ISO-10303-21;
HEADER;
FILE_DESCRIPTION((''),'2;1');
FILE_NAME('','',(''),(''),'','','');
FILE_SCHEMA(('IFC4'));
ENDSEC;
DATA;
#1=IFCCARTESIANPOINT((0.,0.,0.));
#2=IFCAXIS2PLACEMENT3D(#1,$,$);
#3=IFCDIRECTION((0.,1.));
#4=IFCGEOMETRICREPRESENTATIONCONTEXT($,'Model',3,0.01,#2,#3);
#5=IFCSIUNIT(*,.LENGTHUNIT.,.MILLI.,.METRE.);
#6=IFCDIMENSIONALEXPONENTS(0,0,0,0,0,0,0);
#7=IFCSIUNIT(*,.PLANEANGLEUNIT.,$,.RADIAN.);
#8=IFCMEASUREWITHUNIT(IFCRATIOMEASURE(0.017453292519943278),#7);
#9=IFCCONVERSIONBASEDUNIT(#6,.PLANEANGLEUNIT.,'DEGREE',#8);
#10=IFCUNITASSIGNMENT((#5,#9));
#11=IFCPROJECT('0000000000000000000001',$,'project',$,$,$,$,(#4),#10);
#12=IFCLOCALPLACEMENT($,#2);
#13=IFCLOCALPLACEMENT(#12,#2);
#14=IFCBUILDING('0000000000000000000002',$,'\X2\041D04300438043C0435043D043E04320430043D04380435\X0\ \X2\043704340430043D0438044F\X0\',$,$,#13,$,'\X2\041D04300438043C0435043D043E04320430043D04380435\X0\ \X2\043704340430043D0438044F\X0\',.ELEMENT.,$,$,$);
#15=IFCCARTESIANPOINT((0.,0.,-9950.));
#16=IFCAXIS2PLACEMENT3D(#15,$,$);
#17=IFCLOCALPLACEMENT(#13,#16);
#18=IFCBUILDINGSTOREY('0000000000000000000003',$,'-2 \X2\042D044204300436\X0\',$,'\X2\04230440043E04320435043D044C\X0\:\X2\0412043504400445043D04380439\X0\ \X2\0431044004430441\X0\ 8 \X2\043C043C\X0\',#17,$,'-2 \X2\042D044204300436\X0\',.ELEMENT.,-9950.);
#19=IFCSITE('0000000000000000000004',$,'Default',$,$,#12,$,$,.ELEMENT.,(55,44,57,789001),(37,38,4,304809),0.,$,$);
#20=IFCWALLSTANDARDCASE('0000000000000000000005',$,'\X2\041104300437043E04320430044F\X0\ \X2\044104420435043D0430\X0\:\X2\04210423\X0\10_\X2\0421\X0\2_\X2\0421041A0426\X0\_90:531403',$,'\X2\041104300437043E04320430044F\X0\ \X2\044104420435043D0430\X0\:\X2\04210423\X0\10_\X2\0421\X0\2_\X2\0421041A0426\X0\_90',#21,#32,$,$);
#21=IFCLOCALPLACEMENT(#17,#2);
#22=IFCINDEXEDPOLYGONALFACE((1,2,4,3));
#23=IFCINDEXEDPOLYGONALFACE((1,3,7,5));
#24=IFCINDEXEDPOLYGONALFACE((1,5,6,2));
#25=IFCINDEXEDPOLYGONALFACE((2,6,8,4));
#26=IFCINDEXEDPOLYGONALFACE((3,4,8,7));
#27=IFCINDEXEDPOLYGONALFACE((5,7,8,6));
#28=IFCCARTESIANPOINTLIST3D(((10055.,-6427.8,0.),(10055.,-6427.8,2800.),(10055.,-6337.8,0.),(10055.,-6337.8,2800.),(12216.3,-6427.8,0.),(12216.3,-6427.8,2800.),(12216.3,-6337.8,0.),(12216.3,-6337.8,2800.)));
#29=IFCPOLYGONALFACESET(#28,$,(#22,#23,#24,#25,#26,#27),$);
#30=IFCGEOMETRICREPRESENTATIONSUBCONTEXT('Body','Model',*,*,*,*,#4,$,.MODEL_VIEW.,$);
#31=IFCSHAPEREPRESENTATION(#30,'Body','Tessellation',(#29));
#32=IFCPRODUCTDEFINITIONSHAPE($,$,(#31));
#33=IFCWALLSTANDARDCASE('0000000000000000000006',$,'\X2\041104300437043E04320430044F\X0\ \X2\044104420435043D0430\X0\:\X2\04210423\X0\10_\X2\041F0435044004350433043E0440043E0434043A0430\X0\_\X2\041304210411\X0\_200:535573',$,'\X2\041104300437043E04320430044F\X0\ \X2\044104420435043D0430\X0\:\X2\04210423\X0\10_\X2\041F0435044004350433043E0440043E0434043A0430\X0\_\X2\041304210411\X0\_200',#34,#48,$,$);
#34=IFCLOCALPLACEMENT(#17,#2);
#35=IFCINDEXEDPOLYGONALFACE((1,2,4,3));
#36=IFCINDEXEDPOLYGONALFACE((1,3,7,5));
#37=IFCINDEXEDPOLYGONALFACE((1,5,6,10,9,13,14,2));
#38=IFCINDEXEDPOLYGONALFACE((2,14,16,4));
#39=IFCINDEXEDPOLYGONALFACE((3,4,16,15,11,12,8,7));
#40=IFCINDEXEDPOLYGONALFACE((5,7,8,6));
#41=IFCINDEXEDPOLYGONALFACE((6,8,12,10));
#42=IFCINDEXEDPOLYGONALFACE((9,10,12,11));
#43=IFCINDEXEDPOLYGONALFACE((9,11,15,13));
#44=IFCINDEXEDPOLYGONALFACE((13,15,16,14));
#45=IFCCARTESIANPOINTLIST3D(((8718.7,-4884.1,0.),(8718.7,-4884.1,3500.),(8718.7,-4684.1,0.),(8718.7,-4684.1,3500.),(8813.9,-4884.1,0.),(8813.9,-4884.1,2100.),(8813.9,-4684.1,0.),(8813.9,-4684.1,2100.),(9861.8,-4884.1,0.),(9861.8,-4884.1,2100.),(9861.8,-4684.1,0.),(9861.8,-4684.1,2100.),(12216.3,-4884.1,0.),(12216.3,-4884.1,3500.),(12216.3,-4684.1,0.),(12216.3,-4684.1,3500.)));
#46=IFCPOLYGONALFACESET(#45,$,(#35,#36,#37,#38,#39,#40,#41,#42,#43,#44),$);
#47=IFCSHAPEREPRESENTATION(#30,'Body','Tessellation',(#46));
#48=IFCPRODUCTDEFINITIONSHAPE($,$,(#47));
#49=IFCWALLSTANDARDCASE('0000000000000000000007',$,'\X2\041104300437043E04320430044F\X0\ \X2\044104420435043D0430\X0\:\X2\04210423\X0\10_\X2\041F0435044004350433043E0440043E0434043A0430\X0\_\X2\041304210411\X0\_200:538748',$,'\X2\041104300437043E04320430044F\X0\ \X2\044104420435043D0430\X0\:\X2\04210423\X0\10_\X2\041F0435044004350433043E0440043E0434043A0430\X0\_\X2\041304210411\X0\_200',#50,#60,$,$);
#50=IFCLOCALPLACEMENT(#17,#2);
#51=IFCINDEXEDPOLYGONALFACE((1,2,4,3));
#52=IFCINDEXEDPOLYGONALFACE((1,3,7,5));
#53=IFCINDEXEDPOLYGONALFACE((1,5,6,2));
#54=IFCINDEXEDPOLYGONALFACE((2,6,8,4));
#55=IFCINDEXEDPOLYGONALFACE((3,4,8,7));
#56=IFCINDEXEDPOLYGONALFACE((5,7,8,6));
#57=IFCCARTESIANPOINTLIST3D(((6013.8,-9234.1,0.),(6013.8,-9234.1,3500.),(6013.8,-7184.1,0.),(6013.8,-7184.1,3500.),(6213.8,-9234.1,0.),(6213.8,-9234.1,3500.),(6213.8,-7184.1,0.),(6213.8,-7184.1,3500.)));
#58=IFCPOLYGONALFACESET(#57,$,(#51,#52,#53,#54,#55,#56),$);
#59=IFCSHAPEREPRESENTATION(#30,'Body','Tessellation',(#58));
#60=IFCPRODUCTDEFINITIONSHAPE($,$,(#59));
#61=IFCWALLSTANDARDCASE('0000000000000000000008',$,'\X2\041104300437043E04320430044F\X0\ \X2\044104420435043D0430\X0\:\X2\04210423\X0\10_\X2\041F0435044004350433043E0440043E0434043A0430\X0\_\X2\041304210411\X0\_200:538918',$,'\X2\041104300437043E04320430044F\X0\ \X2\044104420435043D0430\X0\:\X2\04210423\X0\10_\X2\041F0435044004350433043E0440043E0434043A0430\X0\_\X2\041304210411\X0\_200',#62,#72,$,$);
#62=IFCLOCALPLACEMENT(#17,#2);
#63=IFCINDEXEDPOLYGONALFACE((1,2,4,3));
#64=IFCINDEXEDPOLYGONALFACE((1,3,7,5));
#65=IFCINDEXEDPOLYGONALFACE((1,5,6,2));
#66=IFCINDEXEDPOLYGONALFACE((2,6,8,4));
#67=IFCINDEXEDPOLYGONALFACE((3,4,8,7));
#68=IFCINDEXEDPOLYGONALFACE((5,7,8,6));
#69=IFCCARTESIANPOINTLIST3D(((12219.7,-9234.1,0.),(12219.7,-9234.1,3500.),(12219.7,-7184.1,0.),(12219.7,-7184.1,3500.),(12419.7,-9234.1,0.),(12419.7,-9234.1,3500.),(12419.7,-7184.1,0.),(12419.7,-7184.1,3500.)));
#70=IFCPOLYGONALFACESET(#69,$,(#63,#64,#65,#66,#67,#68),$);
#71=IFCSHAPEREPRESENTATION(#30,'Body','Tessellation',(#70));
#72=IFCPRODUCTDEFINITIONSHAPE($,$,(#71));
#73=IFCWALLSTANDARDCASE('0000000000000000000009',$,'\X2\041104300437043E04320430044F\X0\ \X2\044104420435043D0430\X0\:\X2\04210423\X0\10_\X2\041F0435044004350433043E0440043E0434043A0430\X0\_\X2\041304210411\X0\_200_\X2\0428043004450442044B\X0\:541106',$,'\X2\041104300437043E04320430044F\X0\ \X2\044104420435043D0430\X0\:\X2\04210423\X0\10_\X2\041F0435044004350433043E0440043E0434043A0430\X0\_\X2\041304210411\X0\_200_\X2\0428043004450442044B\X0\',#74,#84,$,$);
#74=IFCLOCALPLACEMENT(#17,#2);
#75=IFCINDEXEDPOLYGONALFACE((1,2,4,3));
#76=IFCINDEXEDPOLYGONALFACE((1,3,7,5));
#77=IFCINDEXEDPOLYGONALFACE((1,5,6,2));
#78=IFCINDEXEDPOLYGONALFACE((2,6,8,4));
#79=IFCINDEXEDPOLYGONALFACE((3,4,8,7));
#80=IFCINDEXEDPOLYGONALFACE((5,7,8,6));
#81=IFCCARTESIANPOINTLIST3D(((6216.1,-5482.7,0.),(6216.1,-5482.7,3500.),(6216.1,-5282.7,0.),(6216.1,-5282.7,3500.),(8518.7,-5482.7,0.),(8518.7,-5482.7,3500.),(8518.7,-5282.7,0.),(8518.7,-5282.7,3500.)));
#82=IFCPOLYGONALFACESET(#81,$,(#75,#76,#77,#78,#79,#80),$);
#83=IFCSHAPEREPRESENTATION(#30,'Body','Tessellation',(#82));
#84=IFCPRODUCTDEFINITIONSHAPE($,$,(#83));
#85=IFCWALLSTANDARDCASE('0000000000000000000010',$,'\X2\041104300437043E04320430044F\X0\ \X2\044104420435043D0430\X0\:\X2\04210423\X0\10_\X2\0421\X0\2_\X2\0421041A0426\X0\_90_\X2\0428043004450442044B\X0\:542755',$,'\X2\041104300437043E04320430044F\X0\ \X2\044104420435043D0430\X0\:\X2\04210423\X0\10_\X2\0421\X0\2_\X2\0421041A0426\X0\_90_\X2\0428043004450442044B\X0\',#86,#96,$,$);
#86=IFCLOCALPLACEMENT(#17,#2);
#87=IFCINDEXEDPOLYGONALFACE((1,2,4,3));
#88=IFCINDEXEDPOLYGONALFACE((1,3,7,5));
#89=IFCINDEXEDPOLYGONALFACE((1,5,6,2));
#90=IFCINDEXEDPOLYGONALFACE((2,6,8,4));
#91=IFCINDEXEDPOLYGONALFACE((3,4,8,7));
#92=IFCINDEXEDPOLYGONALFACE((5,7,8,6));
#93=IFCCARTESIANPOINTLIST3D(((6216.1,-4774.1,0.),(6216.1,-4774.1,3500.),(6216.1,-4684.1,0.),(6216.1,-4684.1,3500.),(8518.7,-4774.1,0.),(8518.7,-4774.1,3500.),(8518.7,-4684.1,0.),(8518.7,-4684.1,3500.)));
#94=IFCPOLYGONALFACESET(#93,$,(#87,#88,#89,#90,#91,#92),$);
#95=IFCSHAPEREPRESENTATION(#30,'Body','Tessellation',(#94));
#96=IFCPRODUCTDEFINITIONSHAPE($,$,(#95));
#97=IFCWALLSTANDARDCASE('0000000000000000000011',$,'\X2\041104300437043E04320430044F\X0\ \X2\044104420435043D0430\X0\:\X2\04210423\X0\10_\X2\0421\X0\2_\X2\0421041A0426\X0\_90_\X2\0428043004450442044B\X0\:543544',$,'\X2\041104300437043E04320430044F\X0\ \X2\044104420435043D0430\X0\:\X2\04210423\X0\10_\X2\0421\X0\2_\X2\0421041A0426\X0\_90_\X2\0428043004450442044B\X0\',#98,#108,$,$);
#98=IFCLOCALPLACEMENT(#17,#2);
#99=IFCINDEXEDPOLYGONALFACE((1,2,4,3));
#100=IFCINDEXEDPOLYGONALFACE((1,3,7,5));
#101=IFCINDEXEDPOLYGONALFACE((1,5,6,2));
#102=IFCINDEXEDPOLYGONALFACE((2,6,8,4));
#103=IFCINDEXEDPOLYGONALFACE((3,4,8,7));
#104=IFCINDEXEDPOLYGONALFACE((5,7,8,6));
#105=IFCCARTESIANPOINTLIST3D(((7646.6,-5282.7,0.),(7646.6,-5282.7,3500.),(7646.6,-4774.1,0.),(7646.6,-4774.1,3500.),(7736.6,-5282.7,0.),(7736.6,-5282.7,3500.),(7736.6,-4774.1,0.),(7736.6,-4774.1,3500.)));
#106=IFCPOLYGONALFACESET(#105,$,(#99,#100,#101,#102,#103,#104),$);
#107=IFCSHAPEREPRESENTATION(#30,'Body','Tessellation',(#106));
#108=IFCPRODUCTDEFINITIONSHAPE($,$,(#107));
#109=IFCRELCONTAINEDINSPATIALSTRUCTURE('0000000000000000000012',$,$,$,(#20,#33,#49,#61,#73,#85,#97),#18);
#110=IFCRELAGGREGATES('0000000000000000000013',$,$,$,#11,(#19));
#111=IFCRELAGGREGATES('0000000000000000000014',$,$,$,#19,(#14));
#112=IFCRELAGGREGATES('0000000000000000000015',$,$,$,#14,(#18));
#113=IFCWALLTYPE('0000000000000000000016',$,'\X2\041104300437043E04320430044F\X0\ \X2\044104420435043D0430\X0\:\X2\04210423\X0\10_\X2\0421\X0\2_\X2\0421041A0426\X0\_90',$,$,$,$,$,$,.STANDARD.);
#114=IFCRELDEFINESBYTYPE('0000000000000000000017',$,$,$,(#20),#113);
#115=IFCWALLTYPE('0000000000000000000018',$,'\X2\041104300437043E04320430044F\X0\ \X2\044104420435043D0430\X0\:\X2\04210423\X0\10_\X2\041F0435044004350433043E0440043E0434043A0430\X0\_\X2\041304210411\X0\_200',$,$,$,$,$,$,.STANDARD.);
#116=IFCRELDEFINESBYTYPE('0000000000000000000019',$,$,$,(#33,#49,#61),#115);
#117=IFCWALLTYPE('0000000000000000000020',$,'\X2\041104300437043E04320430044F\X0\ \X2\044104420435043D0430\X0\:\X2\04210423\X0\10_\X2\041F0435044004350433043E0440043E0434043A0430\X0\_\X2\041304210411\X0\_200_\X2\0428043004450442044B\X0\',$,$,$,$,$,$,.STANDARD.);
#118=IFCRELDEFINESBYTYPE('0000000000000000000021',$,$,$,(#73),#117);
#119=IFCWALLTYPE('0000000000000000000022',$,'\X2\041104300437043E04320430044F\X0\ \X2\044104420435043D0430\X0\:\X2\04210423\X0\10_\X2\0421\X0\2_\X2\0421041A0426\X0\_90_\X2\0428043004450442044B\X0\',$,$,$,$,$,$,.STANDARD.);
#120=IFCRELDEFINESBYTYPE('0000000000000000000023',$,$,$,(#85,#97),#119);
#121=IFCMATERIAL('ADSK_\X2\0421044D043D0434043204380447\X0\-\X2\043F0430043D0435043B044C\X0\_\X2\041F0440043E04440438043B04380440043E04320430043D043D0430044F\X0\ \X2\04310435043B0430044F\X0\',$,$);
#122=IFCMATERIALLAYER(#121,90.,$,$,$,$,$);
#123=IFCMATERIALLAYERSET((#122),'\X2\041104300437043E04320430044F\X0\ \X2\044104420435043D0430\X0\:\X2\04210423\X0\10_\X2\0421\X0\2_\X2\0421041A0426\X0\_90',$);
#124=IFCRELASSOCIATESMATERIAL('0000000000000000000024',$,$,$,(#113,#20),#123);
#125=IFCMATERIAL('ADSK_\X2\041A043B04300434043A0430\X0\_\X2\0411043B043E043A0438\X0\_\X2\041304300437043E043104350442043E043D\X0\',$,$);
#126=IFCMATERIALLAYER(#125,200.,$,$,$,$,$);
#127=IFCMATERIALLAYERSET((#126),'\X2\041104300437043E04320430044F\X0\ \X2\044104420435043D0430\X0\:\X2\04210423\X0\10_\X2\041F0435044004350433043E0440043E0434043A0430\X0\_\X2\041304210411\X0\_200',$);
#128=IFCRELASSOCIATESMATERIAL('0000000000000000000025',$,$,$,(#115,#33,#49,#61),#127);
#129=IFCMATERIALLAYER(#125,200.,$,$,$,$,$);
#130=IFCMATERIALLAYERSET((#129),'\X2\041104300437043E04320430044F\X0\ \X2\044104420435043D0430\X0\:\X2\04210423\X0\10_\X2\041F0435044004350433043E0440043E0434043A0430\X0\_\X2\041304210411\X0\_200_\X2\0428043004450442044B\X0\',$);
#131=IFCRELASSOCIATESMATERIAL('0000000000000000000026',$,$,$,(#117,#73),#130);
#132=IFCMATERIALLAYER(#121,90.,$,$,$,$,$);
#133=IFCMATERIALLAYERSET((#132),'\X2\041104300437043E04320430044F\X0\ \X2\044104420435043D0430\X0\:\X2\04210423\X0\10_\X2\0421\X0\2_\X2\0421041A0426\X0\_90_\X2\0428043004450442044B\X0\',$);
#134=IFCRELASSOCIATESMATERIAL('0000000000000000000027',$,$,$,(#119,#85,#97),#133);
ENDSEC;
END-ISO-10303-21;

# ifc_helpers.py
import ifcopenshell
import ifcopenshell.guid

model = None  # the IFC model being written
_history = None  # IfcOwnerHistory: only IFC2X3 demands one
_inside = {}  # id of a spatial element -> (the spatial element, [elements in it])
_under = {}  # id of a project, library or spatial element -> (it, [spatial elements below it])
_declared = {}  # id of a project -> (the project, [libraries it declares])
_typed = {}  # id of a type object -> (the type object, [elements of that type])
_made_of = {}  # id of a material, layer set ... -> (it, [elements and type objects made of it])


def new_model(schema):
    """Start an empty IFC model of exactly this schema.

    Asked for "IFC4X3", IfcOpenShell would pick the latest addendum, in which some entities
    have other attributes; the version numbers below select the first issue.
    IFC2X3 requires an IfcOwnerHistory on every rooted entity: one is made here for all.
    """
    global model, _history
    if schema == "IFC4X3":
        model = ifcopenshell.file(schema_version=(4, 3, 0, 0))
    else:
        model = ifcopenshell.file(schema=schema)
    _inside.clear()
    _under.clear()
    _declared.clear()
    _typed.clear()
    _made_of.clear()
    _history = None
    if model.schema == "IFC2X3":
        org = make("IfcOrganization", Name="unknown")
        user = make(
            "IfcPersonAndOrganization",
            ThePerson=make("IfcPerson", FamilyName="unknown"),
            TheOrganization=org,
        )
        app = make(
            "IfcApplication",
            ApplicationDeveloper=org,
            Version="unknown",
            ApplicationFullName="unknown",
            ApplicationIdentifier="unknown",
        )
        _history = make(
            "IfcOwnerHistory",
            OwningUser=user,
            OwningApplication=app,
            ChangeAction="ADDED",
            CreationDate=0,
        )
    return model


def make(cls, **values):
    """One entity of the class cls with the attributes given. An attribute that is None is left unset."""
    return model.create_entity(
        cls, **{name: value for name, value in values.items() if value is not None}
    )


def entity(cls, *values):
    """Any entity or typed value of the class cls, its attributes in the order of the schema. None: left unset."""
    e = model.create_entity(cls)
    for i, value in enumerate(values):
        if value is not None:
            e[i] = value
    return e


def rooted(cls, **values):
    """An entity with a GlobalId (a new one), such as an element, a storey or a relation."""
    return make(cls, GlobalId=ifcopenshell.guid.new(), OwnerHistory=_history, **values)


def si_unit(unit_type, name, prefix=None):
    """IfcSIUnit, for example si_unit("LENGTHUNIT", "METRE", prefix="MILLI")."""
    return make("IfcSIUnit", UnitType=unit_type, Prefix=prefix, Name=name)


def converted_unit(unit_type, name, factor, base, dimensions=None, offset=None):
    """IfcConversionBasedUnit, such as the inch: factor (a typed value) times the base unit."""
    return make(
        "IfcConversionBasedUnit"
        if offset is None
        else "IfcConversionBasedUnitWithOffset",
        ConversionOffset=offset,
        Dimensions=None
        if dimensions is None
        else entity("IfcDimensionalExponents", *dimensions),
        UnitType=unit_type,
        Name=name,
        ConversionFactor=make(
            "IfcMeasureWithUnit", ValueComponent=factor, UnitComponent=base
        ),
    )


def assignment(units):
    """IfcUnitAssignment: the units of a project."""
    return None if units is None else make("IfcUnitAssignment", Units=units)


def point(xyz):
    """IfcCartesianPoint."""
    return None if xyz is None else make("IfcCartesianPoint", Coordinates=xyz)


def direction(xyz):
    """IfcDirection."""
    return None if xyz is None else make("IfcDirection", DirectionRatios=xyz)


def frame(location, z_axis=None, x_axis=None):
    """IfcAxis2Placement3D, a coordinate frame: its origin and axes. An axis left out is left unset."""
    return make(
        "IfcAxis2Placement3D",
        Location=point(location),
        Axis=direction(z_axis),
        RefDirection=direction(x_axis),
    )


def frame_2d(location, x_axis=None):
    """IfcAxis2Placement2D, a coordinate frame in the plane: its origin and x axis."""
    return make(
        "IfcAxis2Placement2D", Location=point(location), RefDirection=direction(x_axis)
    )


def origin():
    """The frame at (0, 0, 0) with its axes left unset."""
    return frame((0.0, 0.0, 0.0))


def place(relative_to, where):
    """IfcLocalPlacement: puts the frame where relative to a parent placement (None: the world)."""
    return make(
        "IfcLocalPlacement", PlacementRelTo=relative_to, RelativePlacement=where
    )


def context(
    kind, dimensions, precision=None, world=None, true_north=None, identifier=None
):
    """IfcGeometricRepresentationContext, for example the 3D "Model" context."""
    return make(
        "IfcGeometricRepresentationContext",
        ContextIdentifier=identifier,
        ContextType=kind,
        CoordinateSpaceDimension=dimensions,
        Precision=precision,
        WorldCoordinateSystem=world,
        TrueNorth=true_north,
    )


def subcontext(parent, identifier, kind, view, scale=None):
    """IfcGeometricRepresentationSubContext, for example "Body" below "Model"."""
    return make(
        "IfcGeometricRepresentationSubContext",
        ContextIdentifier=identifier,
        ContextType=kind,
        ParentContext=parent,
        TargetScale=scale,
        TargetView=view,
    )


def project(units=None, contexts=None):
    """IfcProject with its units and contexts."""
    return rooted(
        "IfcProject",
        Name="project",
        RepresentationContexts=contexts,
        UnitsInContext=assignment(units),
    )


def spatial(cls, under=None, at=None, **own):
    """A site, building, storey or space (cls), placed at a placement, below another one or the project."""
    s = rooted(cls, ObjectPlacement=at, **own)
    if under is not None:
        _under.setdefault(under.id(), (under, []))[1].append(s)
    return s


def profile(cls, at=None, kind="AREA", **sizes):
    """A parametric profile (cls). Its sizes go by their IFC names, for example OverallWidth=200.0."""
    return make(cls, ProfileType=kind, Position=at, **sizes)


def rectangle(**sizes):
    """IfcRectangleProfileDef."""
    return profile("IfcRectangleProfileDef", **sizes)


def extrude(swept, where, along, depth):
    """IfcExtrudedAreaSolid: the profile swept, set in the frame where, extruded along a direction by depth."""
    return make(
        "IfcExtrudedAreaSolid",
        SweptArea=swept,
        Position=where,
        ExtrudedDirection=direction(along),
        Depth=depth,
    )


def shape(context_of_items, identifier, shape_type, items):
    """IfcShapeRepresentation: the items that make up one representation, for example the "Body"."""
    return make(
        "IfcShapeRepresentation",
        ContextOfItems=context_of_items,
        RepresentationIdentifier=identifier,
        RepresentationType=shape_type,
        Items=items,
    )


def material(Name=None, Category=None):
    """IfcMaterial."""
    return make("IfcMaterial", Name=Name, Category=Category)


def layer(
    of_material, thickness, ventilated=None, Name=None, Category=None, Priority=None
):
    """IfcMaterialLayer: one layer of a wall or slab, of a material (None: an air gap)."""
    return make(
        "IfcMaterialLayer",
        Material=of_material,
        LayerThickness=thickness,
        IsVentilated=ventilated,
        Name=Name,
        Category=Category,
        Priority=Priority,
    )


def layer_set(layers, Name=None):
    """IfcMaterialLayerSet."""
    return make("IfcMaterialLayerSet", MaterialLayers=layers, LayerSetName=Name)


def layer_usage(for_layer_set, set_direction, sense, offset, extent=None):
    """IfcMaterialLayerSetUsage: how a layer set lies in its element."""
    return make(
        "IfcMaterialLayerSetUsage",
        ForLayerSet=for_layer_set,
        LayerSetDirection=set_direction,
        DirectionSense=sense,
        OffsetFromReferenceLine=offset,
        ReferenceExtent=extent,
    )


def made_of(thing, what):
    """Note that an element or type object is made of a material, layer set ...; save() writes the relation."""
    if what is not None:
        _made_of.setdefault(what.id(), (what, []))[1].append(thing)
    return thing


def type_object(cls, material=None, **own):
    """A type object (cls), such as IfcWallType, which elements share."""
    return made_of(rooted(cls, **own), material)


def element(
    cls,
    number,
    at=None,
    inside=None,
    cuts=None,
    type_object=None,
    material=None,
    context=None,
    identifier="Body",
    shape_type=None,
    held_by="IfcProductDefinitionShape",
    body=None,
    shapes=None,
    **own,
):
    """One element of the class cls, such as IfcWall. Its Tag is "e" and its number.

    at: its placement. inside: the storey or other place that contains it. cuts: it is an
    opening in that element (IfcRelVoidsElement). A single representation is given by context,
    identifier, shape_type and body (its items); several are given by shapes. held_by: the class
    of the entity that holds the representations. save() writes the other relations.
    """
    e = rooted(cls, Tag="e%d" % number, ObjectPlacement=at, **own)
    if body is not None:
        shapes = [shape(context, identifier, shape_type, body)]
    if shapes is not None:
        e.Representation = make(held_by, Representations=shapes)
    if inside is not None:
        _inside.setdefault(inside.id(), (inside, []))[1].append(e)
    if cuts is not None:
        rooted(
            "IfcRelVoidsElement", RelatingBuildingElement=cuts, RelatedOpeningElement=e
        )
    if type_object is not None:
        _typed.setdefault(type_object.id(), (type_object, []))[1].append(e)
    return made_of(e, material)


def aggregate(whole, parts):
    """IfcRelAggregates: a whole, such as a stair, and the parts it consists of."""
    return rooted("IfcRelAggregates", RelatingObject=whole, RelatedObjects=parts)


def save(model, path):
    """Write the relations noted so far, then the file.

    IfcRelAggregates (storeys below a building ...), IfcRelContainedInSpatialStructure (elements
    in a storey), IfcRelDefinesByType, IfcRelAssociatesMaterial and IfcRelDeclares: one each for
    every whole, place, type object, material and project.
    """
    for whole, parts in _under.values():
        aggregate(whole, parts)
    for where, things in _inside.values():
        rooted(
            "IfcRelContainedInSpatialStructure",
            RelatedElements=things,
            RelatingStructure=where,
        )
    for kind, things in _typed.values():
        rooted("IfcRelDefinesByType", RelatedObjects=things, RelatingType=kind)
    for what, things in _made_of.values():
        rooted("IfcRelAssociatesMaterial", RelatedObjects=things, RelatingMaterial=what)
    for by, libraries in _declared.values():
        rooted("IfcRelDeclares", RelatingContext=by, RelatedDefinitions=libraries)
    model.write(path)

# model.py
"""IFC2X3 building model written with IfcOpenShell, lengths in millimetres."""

from ifc_helpers import new_model, entity, si_unit, converted_unit, direction, frame, frame_2d, origin, place, context, subcontext, project, spatial, rectangle, extrude, material, layer, layer_set, layer_usage, type_object, element, save


model = new_model("IFC2X3")

# Units and contexts
model_context = context("Model", 3, precision=0.01, world=origin(), true_north=direction((0.0, 1.0)))
body_context = subcontext(model_context, "Body", "Model", "MODEL_VIEW")
ifc_project = project(units=[si_unit("LENGTHUNIT", "METRE", prefix="MILLI"), converted_unit("PLANEANGLEUNIT", "DEGREE", entity("IfcRatioMeasure", 0.017453292519943278), si_unit("PLANEANGLEUNIT", "RADIAN"), dimensions=[0, 0, 0, 0, 0, 0, 0])], contexts=[model_context])

# Site, building, storey
site_placement = place(None, origin())
site = spatial("IfcSite", under=ifc_project, at=site_placement, Name="Default", CompositionType="ELEMENT", RefLatitude=(55, 44, 57, 789001), RefLongitude=(37, 38, 4, 304809), RefElevation=0.0)
building_placement = place(site_placement, origin())
building = spatial("IfcBuilding", under=site, at=building_placement, Name="Наименование здания", LongName="Наименование здания", CompositionType="ELEMENT")
storey_placement = place(building_placement, frame((0.0, 0.0, -9950.0)))
storey = spatial("IfcBuildingStorey", under=building, at=storey_placement, Name="-2 Этаж", ObjectType="Уровень:Верхний брус 8 мм", LongName="-2 Этаж", CompositionType="ELEMENT", Elevation=-9950.0)

# Shared definitions
ifc_material_1 = material(Name="ADSK_Сэндвич-панель_Профилированная белая")
ifc_layer_1 = layer(ifc_material_1, 90.0)
ifc_layer_set_1 = layer_set([ifc_layer_1], Name="Базовая стена:СУ10_С2_СКЦ_90")
ifc_layer_usage_1 = layer_usage(ifc_layer_set_1, "AXIS2", "NEGATIVE", 45.0)
wall_type_1 = type_object("IfcWallType", Name="Базовая стена:СУ10_С2_СКЦ_90", PredefinedType="STANDARD", material=ifc_layer_set_1)

# Wall
wall_1_placement = place(storey_placement, frame((12216.3, -6382.8, 0.0), z_axis=(0.0, 0.0, 1.0), x_axis=(-1.0, 0.0, 0.0)))
element("IfcWallStandardCase", 1, at=wall_1_placement, inside=storey, type_object=wall_type_1, material=ifc_layer_usage_1, Name="Базовая стена:СУ10_С2_СКЦ_90:531403", ObjectType="Базовая стена:СУ10_С2_СКЦ_90", context=body_context, shape_type="SweptSolid", body=[
    extrude(rectangle(XDim=2161.3, YDim=90.0, at=frame_2d((1080.7, 0.0), x_axis=(-1.0, 0.0))), origin(), (0.0, 0.0, 1.0), 2800.0),
])

# Wall, opening
ifc_material_2 = material(Name="ADSK_Кладка_Блоки_Газобетон")
ifc_layer_2 = layer(ifc_material_2, 200.0)
ifc_layer_set_2 = layer_set([ifc_layer_2], Name="Базовая стена:СУ10_Перегородка_ГСБ_200")
ifc_layer_usage_2 = layer_usage(ifc_layer_set_2, "AXIS2", "NEGATIVE", 100.0)
wall_type_2 = type_object("IfcWallType", Name="Базовая стена:СУ10_Перегородка_ГСБ_200", PredefinedType="STANDARD", material=ifc_layer_set_2)
wall_2_placement = place(storey_placement, frame((12216.3, -4784.1, 0.0), z_axis=(0.0, 0.0, 1.0), x_axis=(-1.0, 0.0, 0.0)))
wall_2 = element("IfcWallStandardCase", 2, at=wall_2_placement, inside=storey, type_object=wall_type_2, material=ifc_layer_usage_2, Name="Базовая стена:СУ10_Перегородка_ГСБ_200:535573", ObjectType="Базовая стена:СУ10_Перегородка_ГСБ_200", context=body_context, shape_type="SweptSolid", body=[
    extrude(rectangle(XDim=3497.6, YDim=200.0, at=frame_2d((1748.8, 0.0), x_axis=(-1.0, 0.0))), origin(), (0.0, 0.0, 1.0), 3500.0),
])
opening_1_placement = place(wall_2_placement, origin())
element("IfcOpeningElement", 3, at=opening_1_placement, cuts=wall_2, ObjectType="Opening", context=body_context, shape_type="SweptSolid", body=[
    extrude(rectangle(XDim=2100.0, YDim=1047.9, at=frame_2d((0.0, 0.0), x_axis=(1.0, 0.0))), frame((2878.5, -100.0, 1050.0), z_axis=(0.0, 1.0, 0.0), x_axis=(0.0, 0.0, -1.0)), (0.0, 0.0, 1.0), 200.0),
])

# Walls
wall_3_placement = place(storey_placement, frame((6113.8, -9234.1, 0.0), z_axis=(0.0, 0.0, 1.0), x_axis=(0.0, 1.0, 0.0)))
element("IfcWallStandardCase", 4, at=wall_3_placement, inside=storey, type_object=wall_type_2, material=ifc_layer_usage_2, Name="Базовая стена:СУ10_Перегородка_ГСБ_200:538748", ObjectType="Базовая стена:СУ10_Перегородка_ГСБ_200", context=body_context, shape_type="SweptSolid", body=[
    extrude(rectangle(XDim=2050.0, YDim=200.0, at=frame_2d((1025.0, 0.0), x_axis=(-1.0, 0.0))), origin(), (0.0, 0.0, 1.0), 3500.0),
])
wall_4_placement = place(storey_placement, frame((12319.7, -9234.1, 0.0), z_axis=(0.0, 0.0, 1.0), x_axis=(0.0, 1.0, 0.0)))
element("IfcWallStandardCase", 5, at=wall_4_placement, inside=storey, type_object=wall_type_2, material=ifc_layer_usage_2, Name="Базовая стена:СУ10_Перегородка_ГСБ_200:538918", ObjectType="Базовая стена:СУ10_Перегородка_ГСБ_200", context=body_context, shape_type="SweptSolid", body=[
    extrude(rectangle(XDim=2050.0, YDim=200.0, at=frame_2d((1025.0, 0.0), x_axis=(-1.0, 0.0))), origin(), (0.0, 0.0, 1.0), 3500.0),
])
ifc_layer_3 = layer(ifc_material_2, 200.0)
ifc_layer_set_3 = layer_set([ifc_layer_3], Name="Базовая стена:СУ10_Перегородка_ГСБ_200_Шахты")
ifc_layer_usage_3 = layer_usage(ifc_layer_set_3, "AXIS2", "NEGATIVE", 100.0)
wall_type_3 = type_object("IfcWallType", Name="Базовая стена:СУ10_Перегородка_ГСБ_200_Шахты", PredefinedType="STANDARD", material=ifc_layer_set_3)
wall_5_placement = place(storey_placement, frame((6216.1, -5382.7, 0.0)))
element("IfcWallStandardCase", 6, at=wall_5_placement, inside=storey, type_object=wall_type_3, material=ifc_layer_usage_3, Name="Базовая стена:СУ10_Перегородка_ГСБ_200_Шахты:541106", ObjectType="Базовая стена:СУ10_Перегородка_ГСБ_200_Шахты", context=body_context, shape_type="SweptSolid", body=[
    extrude(rectangle(XDim=2302.6, YDim=200.0, at=frame_2d((1151.3, 0.0), x_axis=(-1.0, 0.0))), origin(), (0.0, 0.0, 1.0), 3500.0),
])
ifc_layer_4 = layer(ifc_material_1, 90.0)
ifc_layer_set_4 = layer_set([ifc_layer_4], Name="Базовая стена:СУ10_С2_СКЦ_90_Шахты")
ifc_layer_usage_4 = layer_usage(ifc_layer_set_4, "AXIS2", "NEGATIVE", 45.0)
wall_type_4 = type_object("IfcWallType", Name="Базовая стена:СУ10_С2_СКЦ_90_Шахты", PredefinedType="STANDARD", material=ifc_layer_set_4)
wall_6_placement = place(storey_placement, frame((8518.7, -4729.1, 0.0), z_axis=(0.0, 0.0, 1.0), x_axis=(-1.0, 0.0, 0.0)))
element("IfcWallStandardCase", 7, at=wall_6_placement, inside=storey, type_object=wall_type_4, material=ifc_layer_usage_4, Name="Базовая стена:СУ10_С2_СКЦ_90_Шахты:542755", ObjectType="Базовая стена:СУ10_С2_СКЦ_90_Шахты", context=body_context, shape_type="SweptSolid", body=[
    extrude(rectangle(XDim=2302.6, YDim=90.0, at=frame_2d((1151.3, 0.0), x_axis=(-1.0, 0.0))), origin(), (0.0, 0.0, 1.0), 3500.0),
])
wall_7_placement = place(storey_placement, frame((7691.6, -5282.7, 0.0), z_axis=(0.0, 0.0, 1.0), x_axis=(0.0, 1.0, 0.0)))
element("IfcWallStandardCase", 8, at=wall_7_placement, inside=storey, type_object=wall_type_4, material=ifc_layer_usage_4, Name="Базовая стена:СУ10_С2_СКЦ_90_Шахты:543544", ObjectType="Базовая стена:СУ10_С2_СКЦ_90_Шахты", context=body_context, shape_type="SweptSolid", body=[
    extrude(rectangle(XDim=508.6, YDim=90.0, at=frame_2d((254.3, 0.0), x_axis=(-1.0, 0.0))), origin(), (0.0, 0.0, 1.0), 3500.0),
])

save(model, "model.ifc")
